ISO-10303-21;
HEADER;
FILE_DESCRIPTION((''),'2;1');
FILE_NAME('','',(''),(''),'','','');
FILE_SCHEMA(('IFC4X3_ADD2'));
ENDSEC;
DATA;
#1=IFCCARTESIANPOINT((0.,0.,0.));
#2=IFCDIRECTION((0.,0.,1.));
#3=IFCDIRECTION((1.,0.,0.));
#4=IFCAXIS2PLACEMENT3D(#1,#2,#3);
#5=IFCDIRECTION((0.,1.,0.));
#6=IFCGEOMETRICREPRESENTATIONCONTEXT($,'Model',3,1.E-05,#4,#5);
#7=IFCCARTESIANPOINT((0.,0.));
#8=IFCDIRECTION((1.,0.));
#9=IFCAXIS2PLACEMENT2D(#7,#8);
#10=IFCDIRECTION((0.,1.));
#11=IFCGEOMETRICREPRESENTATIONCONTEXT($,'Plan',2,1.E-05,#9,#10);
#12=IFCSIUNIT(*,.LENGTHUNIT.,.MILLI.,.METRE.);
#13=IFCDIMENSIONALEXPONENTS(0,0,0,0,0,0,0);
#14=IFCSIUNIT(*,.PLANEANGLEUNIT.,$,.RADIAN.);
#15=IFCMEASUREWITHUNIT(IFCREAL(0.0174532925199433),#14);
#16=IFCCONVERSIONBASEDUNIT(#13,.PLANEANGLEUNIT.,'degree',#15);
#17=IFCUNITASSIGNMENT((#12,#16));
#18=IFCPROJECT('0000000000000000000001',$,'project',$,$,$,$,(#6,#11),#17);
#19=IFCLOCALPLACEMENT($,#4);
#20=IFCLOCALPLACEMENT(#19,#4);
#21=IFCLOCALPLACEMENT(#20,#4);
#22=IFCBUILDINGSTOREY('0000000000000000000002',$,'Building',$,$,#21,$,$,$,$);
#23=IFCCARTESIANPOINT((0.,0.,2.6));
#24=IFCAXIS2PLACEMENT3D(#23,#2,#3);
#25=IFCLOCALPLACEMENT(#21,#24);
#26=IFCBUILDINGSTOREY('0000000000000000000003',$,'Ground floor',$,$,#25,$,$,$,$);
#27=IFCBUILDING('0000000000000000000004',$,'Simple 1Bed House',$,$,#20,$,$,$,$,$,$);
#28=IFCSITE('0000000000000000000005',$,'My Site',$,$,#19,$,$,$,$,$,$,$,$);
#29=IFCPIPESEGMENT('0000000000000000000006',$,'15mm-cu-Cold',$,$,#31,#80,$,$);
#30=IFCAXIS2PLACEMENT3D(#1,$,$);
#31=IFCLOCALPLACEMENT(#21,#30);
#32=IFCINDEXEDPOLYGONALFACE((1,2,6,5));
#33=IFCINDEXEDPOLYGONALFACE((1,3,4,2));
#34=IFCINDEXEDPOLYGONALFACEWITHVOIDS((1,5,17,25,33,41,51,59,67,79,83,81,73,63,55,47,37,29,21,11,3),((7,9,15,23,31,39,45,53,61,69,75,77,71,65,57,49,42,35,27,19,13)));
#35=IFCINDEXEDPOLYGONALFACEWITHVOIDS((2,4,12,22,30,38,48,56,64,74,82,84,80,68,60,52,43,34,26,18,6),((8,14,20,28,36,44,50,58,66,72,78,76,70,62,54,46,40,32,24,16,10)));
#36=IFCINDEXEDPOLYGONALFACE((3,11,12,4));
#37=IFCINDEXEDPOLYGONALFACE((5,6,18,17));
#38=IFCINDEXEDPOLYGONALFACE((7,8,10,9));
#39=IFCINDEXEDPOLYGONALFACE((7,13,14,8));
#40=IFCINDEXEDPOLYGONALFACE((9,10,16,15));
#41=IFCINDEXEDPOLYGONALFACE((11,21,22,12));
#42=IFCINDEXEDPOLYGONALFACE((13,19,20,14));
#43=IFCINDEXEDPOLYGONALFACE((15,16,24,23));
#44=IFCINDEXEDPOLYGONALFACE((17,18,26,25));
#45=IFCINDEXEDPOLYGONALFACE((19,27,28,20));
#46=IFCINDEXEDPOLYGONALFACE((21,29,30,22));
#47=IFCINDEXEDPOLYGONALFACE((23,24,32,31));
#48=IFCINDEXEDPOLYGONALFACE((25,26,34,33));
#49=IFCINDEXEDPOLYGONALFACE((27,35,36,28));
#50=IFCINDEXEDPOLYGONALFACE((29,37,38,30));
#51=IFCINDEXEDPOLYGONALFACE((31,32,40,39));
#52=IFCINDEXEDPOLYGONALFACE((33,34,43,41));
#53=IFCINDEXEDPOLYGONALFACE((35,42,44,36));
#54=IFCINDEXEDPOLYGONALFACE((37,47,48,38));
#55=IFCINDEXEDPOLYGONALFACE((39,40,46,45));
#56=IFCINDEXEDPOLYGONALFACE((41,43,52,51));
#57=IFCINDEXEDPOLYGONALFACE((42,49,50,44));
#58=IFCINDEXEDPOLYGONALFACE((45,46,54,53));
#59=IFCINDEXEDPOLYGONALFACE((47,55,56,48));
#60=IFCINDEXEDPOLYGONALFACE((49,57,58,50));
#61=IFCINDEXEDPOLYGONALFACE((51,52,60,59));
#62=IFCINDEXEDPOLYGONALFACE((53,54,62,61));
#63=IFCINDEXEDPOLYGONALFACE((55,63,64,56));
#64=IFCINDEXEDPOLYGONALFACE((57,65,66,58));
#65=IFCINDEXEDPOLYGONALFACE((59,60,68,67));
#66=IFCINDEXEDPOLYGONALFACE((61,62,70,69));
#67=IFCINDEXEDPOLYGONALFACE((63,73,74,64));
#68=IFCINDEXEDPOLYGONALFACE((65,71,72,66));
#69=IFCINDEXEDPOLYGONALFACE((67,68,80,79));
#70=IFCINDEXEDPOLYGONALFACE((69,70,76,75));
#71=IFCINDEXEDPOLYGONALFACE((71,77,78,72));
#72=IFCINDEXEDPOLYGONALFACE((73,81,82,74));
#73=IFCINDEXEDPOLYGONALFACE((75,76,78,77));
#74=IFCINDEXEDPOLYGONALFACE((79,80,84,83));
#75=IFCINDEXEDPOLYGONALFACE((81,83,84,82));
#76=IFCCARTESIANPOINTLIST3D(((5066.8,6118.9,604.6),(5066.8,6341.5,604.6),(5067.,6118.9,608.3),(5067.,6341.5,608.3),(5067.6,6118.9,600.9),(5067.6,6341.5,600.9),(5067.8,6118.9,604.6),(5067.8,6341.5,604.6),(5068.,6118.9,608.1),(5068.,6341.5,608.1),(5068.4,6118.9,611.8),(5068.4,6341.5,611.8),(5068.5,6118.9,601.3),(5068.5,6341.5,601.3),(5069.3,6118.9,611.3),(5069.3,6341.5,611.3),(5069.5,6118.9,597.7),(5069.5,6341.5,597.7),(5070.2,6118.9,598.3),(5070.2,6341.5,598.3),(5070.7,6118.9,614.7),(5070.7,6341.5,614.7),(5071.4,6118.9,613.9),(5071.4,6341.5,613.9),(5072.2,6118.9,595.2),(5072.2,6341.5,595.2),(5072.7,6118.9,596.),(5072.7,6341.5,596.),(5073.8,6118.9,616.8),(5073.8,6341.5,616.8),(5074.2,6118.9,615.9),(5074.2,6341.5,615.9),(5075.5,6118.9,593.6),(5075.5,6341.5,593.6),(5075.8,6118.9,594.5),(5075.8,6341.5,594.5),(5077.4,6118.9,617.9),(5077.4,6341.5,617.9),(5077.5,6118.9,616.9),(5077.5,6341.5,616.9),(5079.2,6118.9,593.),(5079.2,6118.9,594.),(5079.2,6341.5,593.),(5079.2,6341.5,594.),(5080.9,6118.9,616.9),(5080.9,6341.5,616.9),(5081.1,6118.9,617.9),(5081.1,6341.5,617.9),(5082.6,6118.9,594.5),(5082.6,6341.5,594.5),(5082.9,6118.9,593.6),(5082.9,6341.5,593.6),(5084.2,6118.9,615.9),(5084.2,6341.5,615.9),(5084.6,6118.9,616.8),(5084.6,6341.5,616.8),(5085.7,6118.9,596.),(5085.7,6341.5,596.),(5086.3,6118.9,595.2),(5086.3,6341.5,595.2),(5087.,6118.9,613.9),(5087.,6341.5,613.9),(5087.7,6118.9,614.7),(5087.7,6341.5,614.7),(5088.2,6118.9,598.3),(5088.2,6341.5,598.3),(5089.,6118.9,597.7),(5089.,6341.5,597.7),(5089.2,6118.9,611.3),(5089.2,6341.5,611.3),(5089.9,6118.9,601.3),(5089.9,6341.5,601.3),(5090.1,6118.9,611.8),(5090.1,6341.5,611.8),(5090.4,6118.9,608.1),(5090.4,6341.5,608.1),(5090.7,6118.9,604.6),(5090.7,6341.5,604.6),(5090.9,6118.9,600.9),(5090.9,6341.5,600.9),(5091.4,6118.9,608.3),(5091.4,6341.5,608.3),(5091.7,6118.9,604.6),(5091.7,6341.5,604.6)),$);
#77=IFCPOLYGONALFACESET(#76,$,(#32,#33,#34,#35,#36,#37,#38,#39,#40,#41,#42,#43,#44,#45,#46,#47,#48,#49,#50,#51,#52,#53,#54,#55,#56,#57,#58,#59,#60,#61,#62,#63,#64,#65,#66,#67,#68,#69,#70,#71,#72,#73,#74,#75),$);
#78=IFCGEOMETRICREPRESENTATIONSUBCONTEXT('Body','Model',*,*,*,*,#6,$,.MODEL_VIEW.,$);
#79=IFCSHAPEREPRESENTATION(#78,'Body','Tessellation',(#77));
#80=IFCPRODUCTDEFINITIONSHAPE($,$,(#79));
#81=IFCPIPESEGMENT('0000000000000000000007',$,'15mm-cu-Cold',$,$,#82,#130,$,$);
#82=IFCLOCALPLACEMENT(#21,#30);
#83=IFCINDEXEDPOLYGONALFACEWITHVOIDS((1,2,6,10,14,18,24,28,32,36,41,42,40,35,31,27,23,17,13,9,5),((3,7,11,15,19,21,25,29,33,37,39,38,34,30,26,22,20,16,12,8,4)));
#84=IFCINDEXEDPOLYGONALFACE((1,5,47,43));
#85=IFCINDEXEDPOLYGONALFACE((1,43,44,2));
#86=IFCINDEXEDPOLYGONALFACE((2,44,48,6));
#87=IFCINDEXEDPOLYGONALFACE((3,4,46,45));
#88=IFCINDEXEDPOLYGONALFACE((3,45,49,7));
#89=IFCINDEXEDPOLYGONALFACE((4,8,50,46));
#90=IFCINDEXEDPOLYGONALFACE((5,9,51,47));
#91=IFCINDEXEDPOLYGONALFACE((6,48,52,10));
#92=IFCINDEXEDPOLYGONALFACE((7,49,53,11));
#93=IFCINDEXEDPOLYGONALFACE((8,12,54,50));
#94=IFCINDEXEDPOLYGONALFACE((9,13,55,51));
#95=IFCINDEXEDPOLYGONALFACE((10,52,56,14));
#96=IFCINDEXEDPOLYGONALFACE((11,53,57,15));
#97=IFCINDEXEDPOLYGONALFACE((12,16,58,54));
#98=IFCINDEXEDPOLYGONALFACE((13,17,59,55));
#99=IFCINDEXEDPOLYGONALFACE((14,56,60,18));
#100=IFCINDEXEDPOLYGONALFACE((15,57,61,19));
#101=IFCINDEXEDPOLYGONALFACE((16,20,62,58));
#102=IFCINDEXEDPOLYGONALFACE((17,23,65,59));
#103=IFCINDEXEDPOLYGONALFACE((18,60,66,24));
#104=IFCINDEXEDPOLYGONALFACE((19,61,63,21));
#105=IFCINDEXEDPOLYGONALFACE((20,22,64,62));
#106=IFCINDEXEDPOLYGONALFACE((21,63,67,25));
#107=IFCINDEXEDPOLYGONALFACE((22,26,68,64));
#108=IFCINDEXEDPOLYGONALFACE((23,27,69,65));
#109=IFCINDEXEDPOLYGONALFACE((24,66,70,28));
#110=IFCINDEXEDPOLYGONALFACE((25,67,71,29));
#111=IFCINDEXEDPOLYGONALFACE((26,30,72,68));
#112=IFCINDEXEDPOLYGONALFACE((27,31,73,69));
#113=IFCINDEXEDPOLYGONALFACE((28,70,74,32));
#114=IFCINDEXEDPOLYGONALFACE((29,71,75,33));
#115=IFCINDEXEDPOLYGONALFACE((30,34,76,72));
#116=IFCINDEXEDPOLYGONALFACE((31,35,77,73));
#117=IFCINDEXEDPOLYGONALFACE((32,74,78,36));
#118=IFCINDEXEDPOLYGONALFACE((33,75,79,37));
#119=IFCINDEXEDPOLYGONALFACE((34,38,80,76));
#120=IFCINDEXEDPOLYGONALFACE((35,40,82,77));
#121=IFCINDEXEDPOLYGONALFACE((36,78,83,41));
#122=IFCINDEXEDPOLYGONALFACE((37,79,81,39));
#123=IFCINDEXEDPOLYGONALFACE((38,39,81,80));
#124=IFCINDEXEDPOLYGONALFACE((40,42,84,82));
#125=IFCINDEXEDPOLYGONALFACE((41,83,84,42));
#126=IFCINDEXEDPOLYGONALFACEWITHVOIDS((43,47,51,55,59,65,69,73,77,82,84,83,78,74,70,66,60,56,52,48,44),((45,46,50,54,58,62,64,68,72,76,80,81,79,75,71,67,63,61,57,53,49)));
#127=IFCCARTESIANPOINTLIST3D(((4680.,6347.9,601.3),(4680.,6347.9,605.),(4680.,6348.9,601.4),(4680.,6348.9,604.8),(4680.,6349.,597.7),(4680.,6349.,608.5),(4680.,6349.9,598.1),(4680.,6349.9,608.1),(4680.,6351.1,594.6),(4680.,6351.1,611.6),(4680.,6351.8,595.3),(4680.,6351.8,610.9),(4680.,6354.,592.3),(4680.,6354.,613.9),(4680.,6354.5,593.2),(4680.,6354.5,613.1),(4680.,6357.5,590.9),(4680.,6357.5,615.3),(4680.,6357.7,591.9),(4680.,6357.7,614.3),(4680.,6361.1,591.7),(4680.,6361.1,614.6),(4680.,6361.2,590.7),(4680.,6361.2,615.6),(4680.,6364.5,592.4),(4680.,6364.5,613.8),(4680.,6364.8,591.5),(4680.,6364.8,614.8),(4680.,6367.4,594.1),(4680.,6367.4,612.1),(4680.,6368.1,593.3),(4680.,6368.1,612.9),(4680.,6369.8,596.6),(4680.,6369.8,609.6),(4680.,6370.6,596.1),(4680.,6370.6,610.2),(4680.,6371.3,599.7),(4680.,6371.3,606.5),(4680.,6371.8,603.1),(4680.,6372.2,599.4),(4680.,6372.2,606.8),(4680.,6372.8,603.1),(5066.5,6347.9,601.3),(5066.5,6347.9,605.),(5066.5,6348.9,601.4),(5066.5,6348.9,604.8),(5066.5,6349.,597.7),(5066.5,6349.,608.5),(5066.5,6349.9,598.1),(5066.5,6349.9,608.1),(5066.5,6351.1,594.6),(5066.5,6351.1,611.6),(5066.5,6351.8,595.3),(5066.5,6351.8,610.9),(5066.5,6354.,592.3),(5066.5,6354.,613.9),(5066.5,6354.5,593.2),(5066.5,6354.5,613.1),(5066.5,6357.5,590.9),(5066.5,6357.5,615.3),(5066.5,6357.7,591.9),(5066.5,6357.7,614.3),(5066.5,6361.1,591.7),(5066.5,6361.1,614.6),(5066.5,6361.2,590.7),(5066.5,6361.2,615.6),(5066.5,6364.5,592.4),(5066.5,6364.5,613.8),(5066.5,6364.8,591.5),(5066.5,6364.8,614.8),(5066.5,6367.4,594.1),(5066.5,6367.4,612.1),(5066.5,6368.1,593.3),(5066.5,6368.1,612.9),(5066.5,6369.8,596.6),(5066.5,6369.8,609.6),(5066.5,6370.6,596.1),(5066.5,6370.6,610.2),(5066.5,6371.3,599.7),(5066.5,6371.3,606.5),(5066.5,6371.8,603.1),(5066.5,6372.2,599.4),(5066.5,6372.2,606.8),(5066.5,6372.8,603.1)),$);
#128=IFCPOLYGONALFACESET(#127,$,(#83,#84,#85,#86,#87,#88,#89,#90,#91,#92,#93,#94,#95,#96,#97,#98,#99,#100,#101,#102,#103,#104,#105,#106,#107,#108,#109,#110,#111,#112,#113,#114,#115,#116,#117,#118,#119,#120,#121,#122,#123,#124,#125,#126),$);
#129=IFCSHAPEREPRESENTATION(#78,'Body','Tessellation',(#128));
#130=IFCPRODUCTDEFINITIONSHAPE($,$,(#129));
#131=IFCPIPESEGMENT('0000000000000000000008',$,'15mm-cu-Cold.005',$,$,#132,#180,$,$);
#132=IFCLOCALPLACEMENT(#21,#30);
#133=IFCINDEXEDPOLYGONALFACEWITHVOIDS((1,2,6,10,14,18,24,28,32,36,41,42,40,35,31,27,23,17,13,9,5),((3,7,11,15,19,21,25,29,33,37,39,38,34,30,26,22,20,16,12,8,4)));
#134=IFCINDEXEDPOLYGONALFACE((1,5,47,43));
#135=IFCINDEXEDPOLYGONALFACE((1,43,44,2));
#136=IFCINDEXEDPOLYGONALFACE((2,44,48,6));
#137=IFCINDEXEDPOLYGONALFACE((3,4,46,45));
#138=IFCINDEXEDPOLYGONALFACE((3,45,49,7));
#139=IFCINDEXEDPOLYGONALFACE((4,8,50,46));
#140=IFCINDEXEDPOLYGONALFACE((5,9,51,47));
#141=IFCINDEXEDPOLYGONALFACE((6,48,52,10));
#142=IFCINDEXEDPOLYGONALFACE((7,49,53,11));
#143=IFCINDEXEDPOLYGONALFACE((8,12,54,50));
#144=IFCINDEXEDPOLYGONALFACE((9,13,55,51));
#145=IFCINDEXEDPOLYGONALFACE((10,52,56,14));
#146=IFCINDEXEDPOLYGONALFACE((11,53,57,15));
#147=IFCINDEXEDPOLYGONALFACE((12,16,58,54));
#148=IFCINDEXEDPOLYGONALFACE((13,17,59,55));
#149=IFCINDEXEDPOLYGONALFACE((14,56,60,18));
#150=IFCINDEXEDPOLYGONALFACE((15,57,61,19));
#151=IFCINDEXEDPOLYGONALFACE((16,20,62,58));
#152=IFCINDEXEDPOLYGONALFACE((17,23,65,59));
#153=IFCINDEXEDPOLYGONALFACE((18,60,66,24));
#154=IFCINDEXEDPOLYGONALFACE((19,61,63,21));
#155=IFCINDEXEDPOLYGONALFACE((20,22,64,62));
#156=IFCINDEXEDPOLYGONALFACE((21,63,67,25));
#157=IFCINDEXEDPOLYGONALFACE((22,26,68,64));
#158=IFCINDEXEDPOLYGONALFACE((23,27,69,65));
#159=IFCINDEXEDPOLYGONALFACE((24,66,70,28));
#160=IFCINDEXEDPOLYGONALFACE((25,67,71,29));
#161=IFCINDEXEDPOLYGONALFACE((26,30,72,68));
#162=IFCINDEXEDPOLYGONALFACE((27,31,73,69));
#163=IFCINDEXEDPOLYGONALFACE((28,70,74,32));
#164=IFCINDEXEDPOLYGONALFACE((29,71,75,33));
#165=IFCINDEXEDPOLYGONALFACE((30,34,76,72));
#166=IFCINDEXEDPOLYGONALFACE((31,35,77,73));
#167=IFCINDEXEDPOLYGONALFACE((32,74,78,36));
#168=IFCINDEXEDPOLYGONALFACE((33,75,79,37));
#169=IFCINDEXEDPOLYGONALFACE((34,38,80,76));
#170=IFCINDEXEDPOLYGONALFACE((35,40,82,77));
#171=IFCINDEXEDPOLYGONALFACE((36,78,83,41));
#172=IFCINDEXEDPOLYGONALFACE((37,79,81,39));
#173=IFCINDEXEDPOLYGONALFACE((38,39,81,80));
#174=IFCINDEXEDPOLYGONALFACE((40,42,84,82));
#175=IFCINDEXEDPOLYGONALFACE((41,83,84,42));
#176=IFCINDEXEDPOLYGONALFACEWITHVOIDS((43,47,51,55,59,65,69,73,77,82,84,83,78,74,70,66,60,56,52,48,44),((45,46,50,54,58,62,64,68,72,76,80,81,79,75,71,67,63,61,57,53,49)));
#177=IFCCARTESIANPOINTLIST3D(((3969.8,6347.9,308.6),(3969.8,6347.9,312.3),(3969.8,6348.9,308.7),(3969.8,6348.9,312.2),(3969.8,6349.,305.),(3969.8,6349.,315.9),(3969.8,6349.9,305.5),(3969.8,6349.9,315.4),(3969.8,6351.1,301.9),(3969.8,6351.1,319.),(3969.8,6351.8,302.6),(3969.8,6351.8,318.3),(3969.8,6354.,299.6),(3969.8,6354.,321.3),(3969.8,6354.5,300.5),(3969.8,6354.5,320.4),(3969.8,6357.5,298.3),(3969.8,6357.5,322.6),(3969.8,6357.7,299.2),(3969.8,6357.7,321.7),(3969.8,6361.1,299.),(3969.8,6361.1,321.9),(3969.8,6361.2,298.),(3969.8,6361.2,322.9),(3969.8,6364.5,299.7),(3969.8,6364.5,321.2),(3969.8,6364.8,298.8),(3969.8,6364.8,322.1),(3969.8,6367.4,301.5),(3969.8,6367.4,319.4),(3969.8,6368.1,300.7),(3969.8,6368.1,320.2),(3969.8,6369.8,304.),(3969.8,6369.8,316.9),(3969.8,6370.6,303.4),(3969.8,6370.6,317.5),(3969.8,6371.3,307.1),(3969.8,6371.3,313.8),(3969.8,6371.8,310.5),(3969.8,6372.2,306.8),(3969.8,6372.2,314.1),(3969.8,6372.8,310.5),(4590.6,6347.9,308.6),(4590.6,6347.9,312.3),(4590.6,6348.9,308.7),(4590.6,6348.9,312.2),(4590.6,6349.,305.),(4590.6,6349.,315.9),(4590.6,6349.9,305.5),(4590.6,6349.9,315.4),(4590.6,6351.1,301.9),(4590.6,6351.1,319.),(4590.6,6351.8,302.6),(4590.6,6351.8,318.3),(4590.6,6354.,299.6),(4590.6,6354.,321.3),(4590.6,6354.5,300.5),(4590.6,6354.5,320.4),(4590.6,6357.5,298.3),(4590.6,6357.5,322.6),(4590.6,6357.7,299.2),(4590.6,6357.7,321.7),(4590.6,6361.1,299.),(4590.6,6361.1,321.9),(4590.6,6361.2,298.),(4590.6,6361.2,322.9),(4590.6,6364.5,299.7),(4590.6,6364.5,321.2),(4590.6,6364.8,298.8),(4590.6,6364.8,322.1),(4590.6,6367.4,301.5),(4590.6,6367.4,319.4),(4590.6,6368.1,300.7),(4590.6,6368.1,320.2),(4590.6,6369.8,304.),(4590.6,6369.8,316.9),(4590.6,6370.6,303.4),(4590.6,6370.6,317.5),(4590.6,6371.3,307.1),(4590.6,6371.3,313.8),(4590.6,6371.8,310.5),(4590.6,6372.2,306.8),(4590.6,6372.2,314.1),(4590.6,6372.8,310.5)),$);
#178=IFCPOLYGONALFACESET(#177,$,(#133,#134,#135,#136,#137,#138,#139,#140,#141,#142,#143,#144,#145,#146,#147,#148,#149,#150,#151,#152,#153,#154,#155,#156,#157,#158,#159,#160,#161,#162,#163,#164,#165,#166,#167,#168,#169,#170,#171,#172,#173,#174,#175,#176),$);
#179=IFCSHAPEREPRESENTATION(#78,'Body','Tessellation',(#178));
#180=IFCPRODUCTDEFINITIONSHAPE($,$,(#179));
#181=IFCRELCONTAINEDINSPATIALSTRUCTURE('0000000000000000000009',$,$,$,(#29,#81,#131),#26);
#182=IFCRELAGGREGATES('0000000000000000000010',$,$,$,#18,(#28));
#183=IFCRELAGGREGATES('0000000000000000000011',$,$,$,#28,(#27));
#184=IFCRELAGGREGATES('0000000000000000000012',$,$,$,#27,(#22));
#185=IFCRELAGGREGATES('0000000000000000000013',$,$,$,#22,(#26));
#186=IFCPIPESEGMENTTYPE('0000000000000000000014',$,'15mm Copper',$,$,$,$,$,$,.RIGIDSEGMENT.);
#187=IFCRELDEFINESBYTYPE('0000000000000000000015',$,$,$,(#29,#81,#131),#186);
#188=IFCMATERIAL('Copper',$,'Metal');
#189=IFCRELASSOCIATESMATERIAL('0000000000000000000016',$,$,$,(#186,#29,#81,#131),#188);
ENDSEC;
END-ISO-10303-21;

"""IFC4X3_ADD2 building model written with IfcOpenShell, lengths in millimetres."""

from ifc_helpers import new_model, entity, si_unit, converted_unit, direction, frame, origin_with_axes, origin_2d_with_axis, place, context, subcontext, project, spatial, hollow_circle, extrude, material, material_profile, profile_set, profile_usage, type_object, element, save


model = new_model("IFC4X3_ADD2")

# Units and contexts
model_context = context("Model", 3, precision=1e-05, world=origin_with_axes(), true_north=direction((0.0, 1.0, 0.0)))
plan_context = context("Plan", 2, precision=1e-05, world=origin_2d_with_axis(), true_north=direction((0.0, 1.0)))
body_context_1 = subcontext(model_context, "Body", "Model", "MODEL_VIEW")
ifc_project = project(units=[si_unit("LENGTHUNIT", "METRE", prefix="MILLI"), converted_unit("PLANEANGLEUNIT", "degree", entity("IfcReal", 0.0174532925199433), si_unit("PLANEANGLEUNIT", "RADIAN"), dimensions=[0, 0, 0, 0, 0, 0, 0])], contexts=[model_context, plan_context])

# Site, building, storeys
site_placement = place(None, origin_with_axes())
site = spatial("IfcSite", under=ifc_project, at=site_placement, Name="My Site")
building_placement = place(site_placement, origin_with_axes())
building = spatial("IfcBuilding", under=site, at=building_placement, Name="Simple 1Bed House")
storey_1_placement = place(building_placement, origin_with_axes())
storey_1 = spatial("IfcBuildingStorey", under=building, at=storey_1_placement, Name="Building")
storey_2_placement = place(storey_1_placement, frame((0.0, 0.0, 2.6), z_axis=(0.0, 0.0, 1.0), x_axis=(1.0, 0.0, 0.0)))
storey_2 = spatial("IfcBuildingStorey", under=storey_1, at=storey_2_placement, Name="Ground floor")

# Pipe segments
ifc_material_1 = material(Name="Copper", Category="Metal")
ifc_material_profile = material_profile(ifc_material_1, hollow_circle(Radius=12.5, WallThickness=1.0))
ifc_profile_set = profile_set([ifc_material_profile])
pipe_segment_type = type_object("IfcPipeSegmentType", Name="15mm Copper", PredefinedType="RIGIDSEGMENT", material=ifc_profile_set)
ifc_profile_usage_1 = profile_usage(ifc_profile_set, cardinal=5)
pipe_segment_1_placement = place(storey_2_placement, frame((5079.2, 6341.5, 602.9), z_axis=(0.0, -1.0, 0.0), x_axis=(0.0, 0.0, -1.0)))
element("IfcPipeSegment", 1, at=pipe_segment_1_placement, inside=storey_2, type_object=pipe_segment_type, material=ifc_profile_usage_1, Name="15mm-cu-Cold", context=body_context_1, shape_type="SweptSolid", body=[
    extrude(hollow_circle(Radius=12.5, WallThickness=1.0), origin_with_axes(), (0.0, 0.0, 1.0), 222.6),
])
ifc_profile_usage_2 = profile_usage(ifc_profile_set, cardinal=5)
pipe_segment_2_placement = place(storey_2_placement, frame((5066.5, 6360.3, 600.5), z_axis=(-1.0, 0.0, 0.0), x_axis=(0.0, 1.0, 0.0)))
element("IfcPipeSegment", 2, at=pipe_segment_2_placement, inside=storey_2, type_object=pipe_segment_type, material=ifc_profile_usage_2, Name="15mm-cu-Cold", context=body_context_1, shape_type="SweptSolid", body=[
    extrude(hollow_circle(Radius=12.5, WallThickness=1.0), origin_with_axes(), (0.0, 0.0, 1.0), 386.5),
])
ifc_profile_usage_3 = profile_usage(ifc_profile_set, cardinal=5)
pipe_segment_3_placement = place(storey_2_placement, frame((3969.8, 6360.3, 307.9), z_axis=(1.0, 0.0, 0.0), x_axis=(0.0, 1.0, 0.0)))
element("IfcPipeSegment", 3, at=pipe_segment_3_placement, inside=storey_2, type_object=pipe_segment_type, material=ifc_profile_usage_3, Name="15mm-cu-Cold.005", context=body_context_1, shape_type="SweptSolid", body=[
    extrude(hollow_circle(Radius=12.5, WallThickness=1.0), origin_with_axes(), (0.0, 0.0, 1.0), 620.8),
])

save(model, "model.ifc")
